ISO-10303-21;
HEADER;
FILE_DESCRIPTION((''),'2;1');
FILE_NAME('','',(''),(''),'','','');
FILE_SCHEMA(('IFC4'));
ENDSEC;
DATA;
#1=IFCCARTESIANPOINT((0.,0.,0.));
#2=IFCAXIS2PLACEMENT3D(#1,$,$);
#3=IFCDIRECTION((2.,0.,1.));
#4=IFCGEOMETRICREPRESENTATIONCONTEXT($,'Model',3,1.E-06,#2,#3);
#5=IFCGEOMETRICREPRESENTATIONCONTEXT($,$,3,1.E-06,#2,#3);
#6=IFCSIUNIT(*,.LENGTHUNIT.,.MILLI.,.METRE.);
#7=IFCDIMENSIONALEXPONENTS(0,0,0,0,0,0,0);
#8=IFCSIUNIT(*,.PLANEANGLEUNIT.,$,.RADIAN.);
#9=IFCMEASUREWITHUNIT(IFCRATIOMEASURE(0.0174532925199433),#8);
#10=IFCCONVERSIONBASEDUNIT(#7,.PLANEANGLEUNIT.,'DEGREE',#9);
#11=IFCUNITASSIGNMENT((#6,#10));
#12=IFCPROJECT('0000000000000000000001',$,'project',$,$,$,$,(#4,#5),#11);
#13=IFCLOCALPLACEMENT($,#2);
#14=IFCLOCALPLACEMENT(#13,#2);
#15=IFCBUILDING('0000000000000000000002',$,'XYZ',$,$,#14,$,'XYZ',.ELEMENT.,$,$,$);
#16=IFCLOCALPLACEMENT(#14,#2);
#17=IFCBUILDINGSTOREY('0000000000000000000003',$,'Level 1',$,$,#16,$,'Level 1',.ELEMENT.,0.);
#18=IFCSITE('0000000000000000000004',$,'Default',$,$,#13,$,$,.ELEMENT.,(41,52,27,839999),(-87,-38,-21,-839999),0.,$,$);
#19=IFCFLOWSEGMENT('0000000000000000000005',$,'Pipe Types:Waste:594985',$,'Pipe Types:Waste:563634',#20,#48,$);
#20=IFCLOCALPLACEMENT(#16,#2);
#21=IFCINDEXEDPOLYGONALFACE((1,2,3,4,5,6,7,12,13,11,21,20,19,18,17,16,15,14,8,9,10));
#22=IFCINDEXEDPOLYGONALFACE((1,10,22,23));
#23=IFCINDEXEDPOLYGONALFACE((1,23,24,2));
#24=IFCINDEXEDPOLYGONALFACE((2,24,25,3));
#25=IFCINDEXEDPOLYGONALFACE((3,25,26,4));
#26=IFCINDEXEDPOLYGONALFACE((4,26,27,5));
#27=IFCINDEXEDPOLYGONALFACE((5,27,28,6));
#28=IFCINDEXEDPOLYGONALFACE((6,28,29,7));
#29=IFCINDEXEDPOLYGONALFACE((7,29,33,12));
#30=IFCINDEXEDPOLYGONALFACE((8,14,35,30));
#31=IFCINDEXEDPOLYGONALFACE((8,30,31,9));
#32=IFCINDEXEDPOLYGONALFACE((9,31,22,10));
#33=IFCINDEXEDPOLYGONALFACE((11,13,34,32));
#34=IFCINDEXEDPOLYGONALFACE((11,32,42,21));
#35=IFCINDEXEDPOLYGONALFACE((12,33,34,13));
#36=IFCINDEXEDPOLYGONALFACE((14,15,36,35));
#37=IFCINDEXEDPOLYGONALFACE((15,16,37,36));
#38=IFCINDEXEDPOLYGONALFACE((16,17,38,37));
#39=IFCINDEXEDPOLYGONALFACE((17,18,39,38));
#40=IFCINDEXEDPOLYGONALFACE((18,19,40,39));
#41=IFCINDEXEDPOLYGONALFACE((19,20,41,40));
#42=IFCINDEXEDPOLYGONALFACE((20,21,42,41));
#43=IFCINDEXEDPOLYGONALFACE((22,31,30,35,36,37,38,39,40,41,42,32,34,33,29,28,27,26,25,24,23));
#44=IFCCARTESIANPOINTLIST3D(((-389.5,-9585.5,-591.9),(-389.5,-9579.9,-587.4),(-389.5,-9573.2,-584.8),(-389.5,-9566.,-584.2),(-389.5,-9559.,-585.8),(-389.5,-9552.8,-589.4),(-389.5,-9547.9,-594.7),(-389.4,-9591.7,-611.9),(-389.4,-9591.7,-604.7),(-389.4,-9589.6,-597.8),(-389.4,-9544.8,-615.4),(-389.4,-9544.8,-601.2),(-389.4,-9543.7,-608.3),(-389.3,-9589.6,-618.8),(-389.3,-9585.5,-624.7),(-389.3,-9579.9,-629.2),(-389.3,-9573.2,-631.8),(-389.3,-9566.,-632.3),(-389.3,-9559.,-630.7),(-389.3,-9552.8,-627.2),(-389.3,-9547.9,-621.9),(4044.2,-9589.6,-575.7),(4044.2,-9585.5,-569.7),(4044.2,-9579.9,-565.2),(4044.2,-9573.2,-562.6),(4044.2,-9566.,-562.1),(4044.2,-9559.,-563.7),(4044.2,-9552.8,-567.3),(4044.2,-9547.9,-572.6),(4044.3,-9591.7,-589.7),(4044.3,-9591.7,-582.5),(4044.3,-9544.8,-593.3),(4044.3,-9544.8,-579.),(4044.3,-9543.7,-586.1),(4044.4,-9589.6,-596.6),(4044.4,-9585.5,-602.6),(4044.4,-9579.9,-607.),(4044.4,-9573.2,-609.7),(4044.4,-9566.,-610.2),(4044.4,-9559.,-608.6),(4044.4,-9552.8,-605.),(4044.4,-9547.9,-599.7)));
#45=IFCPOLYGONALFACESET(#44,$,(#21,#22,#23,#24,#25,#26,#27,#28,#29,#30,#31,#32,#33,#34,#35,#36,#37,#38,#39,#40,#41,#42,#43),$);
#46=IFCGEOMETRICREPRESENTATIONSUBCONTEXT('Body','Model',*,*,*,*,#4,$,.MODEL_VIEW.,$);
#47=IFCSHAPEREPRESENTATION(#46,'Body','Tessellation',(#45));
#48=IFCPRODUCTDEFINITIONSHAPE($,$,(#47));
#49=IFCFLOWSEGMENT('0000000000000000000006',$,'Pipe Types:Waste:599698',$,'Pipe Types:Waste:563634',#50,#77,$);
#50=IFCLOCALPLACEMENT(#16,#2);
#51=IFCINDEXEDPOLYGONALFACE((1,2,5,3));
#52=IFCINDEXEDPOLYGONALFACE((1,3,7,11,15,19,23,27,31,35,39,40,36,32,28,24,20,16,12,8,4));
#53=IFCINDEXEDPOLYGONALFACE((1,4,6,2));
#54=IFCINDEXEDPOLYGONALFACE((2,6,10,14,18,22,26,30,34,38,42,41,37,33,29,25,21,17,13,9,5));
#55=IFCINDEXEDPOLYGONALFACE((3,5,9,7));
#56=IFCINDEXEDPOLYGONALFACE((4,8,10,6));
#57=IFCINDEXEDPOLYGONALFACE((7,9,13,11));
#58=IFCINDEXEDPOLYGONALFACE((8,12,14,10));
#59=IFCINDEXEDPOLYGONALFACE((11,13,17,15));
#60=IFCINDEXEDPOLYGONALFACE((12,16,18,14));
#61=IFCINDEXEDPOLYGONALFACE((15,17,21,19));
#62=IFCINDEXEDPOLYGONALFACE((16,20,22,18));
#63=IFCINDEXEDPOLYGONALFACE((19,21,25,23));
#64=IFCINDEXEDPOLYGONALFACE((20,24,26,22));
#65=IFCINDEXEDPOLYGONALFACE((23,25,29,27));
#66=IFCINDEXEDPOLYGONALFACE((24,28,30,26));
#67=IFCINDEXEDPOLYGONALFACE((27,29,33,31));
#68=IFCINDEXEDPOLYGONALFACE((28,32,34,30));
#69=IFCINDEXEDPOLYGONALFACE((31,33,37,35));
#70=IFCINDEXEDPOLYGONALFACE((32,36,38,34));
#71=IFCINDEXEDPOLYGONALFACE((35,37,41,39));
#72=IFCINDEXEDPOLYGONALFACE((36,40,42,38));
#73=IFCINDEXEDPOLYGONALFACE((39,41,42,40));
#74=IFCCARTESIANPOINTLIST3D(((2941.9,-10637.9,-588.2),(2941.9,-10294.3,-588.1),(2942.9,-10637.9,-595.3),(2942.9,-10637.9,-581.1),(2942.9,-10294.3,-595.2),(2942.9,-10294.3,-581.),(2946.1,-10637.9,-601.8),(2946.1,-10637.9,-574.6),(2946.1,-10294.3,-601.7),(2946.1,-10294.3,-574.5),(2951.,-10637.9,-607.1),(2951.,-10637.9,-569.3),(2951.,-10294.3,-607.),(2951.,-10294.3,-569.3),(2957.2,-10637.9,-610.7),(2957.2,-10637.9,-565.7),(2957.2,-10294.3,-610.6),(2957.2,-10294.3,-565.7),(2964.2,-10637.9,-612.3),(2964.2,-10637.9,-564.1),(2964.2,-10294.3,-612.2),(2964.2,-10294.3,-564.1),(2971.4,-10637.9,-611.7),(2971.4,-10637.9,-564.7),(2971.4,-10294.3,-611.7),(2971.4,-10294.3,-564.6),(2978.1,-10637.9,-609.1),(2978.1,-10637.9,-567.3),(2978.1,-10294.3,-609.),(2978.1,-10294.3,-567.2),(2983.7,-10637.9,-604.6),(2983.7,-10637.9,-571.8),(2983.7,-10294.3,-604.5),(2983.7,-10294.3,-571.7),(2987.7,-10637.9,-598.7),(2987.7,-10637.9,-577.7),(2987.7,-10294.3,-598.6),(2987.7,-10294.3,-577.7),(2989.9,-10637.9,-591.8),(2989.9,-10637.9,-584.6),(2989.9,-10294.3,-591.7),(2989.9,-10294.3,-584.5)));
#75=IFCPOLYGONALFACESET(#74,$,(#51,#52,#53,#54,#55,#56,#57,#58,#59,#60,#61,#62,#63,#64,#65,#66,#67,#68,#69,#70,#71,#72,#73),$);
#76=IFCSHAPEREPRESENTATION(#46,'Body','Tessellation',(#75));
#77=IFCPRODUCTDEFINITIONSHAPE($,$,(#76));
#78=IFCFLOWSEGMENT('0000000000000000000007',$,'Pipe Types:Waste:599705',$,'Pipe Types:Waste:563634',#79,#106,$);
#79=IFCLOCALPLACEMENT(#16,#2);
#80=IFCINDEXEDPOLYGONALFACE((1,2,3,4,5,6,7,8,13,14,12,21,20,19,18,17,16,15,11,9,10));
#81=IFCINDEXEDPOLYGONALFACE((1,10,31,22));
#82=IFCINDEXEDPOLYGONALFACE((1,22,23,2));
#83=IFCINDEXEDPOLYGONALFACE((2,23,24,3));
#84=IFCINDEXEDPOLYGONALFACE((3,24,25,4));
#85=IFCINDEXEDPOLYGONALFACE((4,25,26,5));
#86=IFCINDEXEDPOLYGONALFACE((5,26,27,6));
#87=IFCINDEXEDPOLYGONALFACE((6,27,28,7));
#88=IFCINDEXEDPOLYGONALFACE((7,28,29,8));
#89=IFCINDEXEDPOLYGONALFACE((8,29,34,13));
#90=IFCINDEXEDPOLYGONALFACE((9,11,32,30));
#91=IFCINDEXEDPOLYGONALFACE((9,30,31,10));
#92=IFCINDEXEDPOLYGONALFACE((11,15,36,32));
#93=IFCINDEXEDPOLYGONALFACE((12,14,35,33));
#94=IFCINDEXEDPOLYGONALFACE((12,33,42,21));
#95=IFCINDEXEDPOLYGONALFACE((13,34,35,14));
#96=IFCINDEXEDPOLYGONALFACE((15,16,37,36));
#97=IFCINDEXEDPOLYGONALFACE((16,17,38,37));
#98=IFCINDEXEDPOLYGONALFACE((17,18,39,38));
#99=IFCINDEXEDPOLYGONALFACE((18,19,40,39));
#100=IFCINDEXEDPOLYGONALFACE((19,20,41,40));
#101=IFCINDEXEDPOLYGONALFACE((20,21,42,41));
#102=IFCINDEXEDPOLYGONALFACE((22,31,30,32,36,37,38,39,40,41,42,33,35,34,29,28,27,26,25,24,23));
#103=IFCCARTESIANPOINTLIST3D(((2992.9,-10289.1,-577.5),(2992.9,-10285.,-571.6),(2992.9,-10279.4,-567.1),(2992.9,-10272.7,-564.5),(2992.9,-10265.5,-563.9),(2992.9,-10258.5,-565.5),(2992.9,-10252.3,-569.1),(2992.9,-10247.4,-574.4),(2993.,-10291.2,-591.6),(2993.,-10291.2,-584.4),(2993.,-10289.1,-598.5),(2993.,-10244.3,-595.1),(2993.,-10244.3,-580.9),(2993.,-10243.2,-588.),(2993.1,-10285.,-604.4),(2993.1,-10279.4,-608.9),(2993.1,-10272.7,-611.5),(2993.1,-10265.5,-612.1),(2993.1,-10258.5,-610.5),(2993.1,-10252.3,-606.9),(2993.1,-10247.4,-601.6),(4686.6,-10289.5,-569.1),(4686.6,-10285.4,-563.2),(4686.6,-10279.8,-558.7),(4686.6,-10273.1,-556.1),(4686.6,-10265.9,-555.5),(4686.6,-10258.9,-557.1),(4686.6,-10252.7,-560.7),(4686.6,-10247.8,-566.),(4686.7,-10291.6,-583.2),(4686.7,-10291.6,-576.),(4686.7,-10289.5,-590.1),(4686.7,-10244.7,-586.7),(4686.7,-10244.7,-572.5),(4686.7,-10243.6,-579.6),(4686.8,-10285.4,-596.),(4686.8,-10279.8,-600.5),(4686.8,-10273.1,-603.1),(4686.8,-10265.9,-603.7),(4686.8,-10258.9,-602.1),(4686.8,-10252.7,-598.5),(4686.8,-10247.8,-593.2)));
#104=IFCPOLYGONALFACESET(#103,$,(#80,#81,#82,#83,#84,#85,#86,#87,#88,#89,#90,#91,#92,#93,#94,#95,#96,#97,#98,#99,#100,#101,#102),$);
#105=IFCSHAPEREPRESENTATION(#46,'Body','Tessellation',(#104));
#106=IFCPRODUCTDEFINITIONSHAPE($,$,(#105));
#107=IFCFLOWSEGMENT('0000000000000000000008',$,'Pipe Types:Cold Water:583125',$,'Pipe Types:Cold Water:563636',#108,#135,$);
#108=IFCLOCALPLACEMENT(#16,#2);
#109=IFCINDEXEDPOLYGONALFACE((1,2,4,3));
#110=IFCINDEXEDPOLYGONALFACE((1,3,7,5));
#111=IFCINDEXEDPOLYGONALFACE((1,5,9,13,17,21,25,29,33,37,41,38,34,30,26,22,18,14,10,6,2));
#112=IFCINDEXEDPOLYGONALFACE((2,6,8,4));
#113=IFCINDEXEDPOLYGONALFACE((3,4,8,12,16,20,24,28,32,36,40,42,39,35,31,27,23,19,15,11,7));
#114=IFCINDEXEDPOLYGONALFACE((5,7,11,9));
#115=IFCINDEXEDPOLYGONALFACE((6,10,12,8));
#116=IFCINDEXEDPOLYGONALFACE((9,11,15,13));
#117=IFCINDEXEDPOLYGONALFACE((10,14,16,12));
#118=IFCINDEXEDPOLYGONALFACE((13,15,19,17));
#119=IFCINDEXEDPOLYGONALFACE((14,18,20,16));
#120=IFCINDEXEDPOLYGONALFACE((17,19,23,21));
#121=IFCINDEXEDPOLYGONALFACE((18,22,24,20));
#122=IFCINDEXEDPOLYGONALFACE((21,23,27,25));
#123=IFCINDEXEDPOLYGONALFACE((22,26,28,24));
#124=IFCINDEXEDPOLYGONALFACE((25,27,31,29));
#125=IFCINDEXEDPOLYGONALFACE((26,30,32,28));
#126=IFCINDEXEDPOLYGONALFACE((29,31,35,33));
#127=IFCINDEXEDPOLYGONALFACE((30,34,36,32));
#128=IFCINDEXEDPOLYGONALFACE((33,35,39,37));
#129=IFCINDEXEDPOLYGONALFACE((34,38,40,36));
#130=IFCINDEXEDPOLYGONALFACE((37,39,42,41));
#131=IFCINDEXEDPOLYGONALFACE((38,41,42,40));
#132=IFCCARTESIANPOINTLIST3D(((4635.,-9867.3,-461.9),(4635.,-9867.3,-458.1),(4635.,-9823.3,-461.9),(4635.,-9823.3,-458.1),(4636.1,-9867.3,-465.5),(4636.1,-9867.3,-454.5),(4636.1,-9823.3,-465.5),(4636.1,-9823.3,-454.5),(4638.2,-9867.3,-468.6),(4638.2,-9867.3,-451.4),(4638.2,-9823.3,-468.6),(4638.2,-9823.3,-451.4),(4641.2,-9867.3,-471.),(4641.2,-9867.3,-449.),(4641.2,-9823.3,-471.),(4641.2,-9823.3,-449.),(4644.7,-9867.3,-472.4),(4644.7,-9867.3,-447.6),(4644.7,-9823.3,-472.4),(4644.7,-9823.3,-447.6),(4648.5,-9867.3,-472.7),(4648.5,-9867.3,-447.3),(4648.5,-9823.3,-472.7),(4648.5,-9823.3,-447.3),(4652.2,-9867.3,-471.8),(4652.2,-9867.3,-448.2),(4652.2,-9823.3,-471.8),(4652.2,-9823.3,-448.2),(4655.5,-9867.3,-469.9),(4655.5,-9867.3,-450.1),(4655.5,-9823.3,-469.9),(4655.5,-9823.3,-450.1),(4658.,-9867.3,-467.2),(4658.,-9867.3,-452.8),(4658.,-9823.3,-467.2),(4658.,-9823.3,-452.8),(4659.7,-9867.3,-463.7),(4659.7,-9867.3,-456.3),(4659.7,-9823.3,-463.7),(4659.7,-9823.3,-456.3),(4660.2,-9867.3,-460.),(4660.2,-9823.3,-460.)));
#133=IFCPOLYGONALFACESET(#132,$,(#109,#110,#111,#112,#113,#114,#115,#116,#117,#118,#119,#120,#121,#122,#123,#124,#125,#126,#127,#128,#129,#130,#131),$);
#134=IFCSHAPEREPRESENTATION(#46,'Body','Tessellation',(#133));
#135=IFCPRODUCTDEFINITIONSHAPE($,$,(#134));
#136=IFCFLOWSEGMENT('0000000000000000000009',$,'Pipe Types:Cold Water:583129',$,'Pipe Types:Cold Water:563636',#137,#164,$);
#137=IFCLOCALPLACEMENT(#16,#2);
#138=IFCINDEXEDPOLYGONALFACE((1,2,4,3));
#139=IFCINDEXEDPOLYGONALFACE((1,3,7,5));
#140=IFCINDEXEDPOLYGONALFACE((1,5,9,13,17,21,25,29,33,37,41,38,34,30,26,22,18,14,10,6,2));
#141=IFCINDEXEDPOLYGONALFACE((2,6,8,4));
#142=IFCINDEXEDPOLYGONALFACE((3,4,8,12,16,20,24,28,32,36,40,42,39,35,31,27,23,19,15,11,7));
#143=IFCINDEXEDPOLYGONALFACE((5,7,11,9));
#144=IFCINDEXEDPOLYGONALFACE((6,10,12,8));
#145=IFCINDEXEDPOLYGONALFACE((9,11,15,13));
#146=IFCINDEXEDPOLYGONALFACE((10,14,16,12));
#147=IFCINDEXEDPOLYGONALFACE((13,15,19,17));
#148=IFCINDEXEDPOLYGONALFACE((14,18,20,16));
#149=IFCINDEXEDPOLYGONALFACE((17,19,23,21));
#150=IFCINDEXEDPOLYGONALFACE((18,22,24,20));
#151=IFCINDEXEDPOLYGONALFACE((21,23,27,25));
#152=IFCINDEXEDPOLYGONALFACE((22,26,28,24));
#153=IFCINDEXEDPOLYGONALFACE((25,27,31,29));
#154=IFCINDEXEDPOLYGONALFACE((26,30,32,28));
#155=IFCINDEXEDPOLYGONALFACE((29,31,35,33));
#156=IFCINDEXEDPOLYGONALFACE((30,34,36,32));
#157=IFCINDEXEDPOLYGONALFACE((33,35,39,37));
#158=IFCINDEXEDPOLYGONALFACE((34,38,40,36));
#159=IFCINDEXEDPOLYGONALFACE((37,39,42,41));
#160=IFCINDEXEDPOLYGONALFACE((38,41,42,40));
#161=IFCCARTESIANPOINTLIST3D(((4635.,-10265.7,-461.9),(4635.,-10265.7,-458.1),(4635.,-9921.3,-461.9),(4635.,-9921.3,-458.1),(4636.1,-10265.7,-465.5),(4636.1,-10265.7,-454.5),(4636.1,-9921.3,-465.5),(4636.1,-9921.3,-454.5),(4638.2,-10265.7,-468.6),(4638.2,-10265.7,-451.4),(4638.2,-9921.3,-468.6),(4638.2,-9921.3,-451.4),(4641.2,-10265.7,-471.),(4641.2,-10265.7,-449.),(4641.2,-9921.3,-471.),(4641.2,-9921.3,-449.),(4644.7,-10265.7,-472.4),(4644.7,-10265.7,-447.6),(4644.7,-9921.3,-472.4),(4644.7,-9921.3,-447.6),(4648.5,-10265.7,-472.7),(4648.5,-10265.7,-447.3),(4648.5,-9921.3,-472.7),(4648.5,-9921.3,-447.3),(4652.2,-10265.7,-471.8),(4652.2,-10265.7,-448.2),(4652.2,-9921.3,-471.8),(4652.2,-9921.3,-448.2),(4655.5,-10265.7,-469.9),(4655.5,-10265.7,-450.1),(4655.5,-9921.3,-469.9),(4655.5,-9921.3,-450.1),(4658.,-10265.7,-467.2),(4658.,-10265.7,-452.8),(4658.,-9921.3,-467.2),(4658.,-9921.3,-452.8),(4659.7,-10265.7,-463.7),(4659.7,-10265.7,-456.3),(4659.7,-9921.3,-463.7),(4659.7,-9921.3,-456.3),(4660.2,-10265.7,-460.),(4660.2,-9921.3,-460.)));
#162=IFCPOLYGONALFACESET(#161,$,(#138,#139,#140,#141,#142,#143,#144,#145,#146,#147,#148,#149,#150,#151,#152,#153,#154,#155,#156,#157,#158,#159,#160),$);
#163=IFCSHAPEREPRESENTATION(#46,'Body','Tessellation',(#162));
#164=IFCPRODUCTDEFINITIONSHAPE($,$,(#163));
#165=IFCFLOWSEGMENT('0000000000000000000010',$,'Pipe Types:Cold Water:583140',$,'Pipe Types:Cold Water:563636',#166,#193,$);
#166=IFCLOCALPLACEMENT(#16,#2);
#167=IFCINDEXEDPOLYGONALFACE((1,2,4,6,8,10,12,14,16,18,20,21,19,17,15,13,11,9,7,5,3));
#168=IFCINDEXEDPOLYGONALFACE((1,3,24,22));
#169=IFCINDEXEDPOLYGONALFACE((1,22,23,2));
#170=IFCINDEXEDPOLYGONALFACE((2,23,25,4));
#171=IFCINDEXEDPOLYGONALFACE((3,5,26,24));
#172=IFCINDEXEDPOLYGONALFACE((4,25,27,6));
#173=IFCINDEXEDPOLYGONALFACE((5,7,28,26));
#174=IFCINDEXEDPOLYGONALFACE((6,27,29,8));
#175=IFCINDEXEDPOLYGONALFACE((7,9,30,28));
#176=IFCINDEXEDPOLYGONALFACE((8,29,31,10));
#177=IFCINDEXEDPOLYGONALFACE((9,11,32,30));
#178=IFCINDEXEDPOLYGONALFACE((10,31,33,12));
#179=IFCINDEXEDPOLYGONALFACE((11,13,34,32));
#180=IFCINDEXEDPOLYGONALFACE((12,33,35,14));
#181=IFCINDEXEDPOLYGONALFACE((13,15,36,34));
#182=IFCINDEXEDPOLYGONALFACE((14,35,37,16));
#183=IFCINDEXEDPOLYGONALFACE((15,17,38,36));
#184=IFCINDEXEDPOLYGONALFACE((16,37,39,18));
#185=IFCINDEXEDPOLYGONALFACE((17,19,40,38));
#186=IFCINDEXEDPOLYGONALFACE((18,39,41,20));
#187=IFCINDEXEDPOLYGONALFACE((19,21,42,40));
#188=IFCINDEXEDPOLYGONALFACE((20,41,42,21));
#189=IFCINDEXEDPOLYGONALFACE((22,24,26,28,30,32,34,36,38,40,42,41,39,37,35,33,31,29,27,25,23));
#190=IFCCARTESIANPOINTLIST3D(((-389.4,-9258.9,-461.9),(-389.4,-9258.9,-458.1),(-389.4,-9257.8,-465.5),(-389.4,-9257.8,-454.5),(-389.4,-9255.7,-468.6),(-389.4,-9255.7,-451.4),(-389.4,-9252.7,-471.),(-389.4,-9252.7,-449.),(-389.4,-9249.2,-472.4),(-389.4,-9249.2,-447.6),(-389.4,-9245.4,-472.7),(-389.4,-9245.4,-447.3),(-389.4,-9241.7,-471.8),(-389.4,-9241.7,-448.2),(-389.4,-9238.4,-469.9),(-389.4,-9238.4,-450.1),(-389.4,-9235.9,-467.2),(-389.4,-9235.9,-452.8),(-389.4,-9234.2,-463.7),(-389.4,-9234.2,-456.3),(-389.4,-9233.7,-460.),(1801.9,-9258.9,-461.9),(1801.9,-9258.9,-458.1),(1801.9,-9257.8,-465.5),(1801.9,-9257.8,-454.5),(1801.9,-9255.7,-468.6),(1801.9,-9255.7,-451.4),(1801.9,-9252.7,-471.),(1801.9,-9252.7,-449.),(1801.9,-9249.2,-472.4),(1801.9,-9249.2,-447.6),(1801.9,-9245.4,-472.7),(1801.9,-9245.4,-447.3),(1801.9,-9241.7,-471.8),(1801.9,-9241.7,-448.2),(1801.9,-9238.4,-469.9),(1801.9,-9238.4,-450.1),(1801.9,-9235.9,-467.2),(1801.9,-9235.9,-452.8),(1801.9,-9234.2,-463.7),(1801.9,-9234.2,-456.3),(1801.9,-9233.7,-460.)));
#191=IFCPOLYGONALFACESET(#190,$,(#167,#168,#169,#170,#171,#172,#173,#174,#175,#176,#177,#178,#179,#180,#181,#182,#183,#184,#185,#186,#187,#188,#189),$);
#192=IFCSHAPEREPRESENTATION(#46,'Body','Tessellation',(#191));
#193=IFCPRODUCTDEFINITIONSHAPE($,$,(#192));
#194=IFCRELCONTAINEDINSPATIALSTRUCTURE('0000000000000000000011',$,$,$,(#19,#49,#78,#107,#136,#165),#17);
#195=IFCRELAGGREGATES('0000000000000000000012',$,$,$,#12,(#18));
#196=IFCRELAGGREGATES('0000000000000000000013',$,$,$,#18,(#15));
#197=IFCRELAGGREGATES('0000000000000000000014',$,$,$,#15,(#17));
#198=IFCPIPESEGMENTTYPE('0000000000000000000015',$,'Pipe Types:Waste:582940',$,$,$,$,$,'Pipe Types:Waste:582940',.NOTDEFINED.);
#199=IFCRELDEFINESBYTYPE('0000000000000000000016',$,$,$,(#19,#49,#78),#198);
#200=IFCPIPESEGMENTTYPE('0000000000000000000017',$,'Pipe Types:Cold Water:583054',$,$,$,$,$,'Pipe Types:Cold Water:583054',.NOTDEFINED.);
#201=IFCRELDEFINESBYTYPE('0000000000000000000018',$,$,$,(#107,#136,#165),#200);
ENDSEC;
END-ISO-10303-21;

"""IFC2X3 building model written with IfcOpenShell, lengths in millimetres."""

from ifc_helpers import new_model, entity, si_unit, converted_unit, direction, frame, frame_2d, origin, origin_2d_with_axis, place, context, subcontext, project, spatial, circle, extrude, type_object, element, save


model = new_model("IFC2X3")

# Units and contexts
model_context = context("Model", 3, precision=1e-06, world=origin(), true_north=direction((2.0, 0.0, 1.0)))
context_of_model = context(None, 3, precision=1e-06, world=origin(), true_north=direction((2.0, 0.0, 1.0)))
body_context = subcontext(model_context, "Body", "Model", "MODEL_VIEW")
ifc_project = project(units=[si_unit("LENGTHUNIT", "METRE", prefix="MILLI"), converted_unit("PLANEANGLEUNIT", "DEGREE", entity("IfcRatioMeasure", 0.0174532925199433), si_unit("PLANEANGLEUNIT", "RADIAN"), dimensions=[0, 0, 0, 0, 0, 0, 0])], contexts=[model_context, context_of_model])

# Site, building, storey
site_placement = place(None, origin())
site = spatial("IfcSite", under=ifc_project, at=site_placement, Name="Default", CompositionType="ELEMENT", RefLatitude=(41, 52, 27, 839999), RefLongitude=(-87, -38, -21, -839999), RefElevation=0.0)
building_placement = place(site_placement, origin())
building = spatial("IfcBuilding", under=site, at=building_placement, Name="XYZ", LongName="XYZ", CompositionType="ELEMENT")
storey_placement = place(building_placement, origin())
storey = spatial("IfcBuildingStorey", under=building, at=storey_placement, Name="Level 1", LongName="Level 1", CompositionType="ELEMENT", Elevation=0.0)

# Flow segments
pipe_segment_type_1 = type_object("IfcPipeSegmentType", Name="Pipe Types:Waste:582940", ElementType="Pipe Types:Waste:582940", PredefinedType="NOTDEFINED")
flow_segment_1_placement = place(storey_placement, origin())
element("IfcFlowSegment", 1, at=flow_segment_1_placement, inside=storey, type_object=pipe_segment_type_1, Name="Pipe Types:Waste:594985", ObjectType="Pipe Types:Waste:563634", context=body_context, shape_type="SweptSolid", body=[
    extrude(circle(Radius=24.1, at=frame_2d((0.0, 0.0), x_axis=(1.0, 0.0))), frame((-389.4, -9567.8, -608.3), z_axis=(0.999988, 0.0, 0.004994), x_axis=(0.0, 1.0, 0.0)), (0.0, 0.0, 1.0), 4433.7),
])
flow_segment_2_placement = place(storey_placement, origin())
element("IfcFlowSegment", 2, at=flow_segment_2_placement, inside=storey, type_object=pipe_segment_type_1, Name="Pipe Types:Waste:599698", ObjectType="Pipe Types:Waste:563634", context=body_context, shape_type="SweptSolid", body=[
    extrude(circle(Radius=24.1, at=origin_2d_with_axis()), frame((2966.0, -10637.9, -588.2), z_axis=(0.0, 1.0, 0.000217), x_axis=(-1.0, 0.0, 0.0)), (0.0, 0.0, 1.0), 343.5),
])
flow_segment_3_placement = place(storey_placement, origin())
element("IfcFlowSegment", 3, at=flow_segment_3_placement, inside=storey, type_object=pipe_segment_type_1, Name="Pipe Types:Waste:599705", ObjectType="Pipe Types:Waste:563634", context=body_context, shape_type="SweptSolid", body=[
    extrude(circle(Radius=24.1, at=origin_2d_with_axis()), frame((2993.0, -10267.3, -588.0), z_axis=(0.999988, -0.000233, 0.004954), x_axis=(0.000233, 1.0, 0.0)), (0.0, 0.0, 1.0), 1693.7),
])
pipe_segment_type_2 = type_object("IfcPipeSegmentType", Name="Pipe Types:Cold Water:583054", ElementType="Pipe Types:Cold Water:583054", PredefinedType="NOTDEFINED")
flow_segment_4_placement = place(storey_placement, origin())
element("IfcFlowSegment", 4, at=flow_segment_4_placement, inside=storey, type_object=pipe_segment_type_2, Name="Pipe Types:Cold Water:583125", ObjectType="Pipe Types:Cold Water:563636", context=body_context, shape_type="SweptSolid", body=[
    extrude(circle(Radius=12.7, at=origin_2d_with_axis()), frame((4647.5, -9867.3, -460.0), z_axis=(0.0, 1.0, 0.0), x_axis=(1.0, 0.0, 0.0)), (0.0, 0.0, 1.0), 44.0),
])
flow_segment_5_placement = place(storey_placement, origin())
element("IfcFlowSegment", 5, at=flow_segment_5_placement, inside=storey, type_object=pipe_segment_type_2, Name="Pipe Types:Cold Water:583129", ObjectType="Pipe Types:Cold Water:563636", context=body_context, shape_type="SweptSolid", body=[
    extrude(circle(Radius=12.7, at=origin_2d_with_axis()), frame((4647.5, -10265.7, -460.0), z_axis=(0.0, 1.0, 0.0), x_axis=(1.0, 0.0, 0.0)), (0.0, 0.0, 1.0), 344.5),
])
flow_segment_6_placement = place(storey_placement, origin())
element("IfcFlowSegment", 6, at=flow_segment_6_placement, inside=storey, type_object=pipe_segment_type_2, Name="Pipe Types:Cold Water:583140", ObjectType="Pipe Types:Cold Water:563636", context=body_context, shape_type="SweptSolid", body=[
    extrude(circle(Radius=12.7, at=frame_2d((0.0, 0.0), x_axis=(1.0, 0.0))), frame((-389.4, -9246.4, -460.0), z_axis=(1.0, 0.0, 0.0), x_axis=(0.0, 1.0, 0.0)), (0.0, 0.0, 1.0), 2191.3),
])

save(model, "model.ifc")
